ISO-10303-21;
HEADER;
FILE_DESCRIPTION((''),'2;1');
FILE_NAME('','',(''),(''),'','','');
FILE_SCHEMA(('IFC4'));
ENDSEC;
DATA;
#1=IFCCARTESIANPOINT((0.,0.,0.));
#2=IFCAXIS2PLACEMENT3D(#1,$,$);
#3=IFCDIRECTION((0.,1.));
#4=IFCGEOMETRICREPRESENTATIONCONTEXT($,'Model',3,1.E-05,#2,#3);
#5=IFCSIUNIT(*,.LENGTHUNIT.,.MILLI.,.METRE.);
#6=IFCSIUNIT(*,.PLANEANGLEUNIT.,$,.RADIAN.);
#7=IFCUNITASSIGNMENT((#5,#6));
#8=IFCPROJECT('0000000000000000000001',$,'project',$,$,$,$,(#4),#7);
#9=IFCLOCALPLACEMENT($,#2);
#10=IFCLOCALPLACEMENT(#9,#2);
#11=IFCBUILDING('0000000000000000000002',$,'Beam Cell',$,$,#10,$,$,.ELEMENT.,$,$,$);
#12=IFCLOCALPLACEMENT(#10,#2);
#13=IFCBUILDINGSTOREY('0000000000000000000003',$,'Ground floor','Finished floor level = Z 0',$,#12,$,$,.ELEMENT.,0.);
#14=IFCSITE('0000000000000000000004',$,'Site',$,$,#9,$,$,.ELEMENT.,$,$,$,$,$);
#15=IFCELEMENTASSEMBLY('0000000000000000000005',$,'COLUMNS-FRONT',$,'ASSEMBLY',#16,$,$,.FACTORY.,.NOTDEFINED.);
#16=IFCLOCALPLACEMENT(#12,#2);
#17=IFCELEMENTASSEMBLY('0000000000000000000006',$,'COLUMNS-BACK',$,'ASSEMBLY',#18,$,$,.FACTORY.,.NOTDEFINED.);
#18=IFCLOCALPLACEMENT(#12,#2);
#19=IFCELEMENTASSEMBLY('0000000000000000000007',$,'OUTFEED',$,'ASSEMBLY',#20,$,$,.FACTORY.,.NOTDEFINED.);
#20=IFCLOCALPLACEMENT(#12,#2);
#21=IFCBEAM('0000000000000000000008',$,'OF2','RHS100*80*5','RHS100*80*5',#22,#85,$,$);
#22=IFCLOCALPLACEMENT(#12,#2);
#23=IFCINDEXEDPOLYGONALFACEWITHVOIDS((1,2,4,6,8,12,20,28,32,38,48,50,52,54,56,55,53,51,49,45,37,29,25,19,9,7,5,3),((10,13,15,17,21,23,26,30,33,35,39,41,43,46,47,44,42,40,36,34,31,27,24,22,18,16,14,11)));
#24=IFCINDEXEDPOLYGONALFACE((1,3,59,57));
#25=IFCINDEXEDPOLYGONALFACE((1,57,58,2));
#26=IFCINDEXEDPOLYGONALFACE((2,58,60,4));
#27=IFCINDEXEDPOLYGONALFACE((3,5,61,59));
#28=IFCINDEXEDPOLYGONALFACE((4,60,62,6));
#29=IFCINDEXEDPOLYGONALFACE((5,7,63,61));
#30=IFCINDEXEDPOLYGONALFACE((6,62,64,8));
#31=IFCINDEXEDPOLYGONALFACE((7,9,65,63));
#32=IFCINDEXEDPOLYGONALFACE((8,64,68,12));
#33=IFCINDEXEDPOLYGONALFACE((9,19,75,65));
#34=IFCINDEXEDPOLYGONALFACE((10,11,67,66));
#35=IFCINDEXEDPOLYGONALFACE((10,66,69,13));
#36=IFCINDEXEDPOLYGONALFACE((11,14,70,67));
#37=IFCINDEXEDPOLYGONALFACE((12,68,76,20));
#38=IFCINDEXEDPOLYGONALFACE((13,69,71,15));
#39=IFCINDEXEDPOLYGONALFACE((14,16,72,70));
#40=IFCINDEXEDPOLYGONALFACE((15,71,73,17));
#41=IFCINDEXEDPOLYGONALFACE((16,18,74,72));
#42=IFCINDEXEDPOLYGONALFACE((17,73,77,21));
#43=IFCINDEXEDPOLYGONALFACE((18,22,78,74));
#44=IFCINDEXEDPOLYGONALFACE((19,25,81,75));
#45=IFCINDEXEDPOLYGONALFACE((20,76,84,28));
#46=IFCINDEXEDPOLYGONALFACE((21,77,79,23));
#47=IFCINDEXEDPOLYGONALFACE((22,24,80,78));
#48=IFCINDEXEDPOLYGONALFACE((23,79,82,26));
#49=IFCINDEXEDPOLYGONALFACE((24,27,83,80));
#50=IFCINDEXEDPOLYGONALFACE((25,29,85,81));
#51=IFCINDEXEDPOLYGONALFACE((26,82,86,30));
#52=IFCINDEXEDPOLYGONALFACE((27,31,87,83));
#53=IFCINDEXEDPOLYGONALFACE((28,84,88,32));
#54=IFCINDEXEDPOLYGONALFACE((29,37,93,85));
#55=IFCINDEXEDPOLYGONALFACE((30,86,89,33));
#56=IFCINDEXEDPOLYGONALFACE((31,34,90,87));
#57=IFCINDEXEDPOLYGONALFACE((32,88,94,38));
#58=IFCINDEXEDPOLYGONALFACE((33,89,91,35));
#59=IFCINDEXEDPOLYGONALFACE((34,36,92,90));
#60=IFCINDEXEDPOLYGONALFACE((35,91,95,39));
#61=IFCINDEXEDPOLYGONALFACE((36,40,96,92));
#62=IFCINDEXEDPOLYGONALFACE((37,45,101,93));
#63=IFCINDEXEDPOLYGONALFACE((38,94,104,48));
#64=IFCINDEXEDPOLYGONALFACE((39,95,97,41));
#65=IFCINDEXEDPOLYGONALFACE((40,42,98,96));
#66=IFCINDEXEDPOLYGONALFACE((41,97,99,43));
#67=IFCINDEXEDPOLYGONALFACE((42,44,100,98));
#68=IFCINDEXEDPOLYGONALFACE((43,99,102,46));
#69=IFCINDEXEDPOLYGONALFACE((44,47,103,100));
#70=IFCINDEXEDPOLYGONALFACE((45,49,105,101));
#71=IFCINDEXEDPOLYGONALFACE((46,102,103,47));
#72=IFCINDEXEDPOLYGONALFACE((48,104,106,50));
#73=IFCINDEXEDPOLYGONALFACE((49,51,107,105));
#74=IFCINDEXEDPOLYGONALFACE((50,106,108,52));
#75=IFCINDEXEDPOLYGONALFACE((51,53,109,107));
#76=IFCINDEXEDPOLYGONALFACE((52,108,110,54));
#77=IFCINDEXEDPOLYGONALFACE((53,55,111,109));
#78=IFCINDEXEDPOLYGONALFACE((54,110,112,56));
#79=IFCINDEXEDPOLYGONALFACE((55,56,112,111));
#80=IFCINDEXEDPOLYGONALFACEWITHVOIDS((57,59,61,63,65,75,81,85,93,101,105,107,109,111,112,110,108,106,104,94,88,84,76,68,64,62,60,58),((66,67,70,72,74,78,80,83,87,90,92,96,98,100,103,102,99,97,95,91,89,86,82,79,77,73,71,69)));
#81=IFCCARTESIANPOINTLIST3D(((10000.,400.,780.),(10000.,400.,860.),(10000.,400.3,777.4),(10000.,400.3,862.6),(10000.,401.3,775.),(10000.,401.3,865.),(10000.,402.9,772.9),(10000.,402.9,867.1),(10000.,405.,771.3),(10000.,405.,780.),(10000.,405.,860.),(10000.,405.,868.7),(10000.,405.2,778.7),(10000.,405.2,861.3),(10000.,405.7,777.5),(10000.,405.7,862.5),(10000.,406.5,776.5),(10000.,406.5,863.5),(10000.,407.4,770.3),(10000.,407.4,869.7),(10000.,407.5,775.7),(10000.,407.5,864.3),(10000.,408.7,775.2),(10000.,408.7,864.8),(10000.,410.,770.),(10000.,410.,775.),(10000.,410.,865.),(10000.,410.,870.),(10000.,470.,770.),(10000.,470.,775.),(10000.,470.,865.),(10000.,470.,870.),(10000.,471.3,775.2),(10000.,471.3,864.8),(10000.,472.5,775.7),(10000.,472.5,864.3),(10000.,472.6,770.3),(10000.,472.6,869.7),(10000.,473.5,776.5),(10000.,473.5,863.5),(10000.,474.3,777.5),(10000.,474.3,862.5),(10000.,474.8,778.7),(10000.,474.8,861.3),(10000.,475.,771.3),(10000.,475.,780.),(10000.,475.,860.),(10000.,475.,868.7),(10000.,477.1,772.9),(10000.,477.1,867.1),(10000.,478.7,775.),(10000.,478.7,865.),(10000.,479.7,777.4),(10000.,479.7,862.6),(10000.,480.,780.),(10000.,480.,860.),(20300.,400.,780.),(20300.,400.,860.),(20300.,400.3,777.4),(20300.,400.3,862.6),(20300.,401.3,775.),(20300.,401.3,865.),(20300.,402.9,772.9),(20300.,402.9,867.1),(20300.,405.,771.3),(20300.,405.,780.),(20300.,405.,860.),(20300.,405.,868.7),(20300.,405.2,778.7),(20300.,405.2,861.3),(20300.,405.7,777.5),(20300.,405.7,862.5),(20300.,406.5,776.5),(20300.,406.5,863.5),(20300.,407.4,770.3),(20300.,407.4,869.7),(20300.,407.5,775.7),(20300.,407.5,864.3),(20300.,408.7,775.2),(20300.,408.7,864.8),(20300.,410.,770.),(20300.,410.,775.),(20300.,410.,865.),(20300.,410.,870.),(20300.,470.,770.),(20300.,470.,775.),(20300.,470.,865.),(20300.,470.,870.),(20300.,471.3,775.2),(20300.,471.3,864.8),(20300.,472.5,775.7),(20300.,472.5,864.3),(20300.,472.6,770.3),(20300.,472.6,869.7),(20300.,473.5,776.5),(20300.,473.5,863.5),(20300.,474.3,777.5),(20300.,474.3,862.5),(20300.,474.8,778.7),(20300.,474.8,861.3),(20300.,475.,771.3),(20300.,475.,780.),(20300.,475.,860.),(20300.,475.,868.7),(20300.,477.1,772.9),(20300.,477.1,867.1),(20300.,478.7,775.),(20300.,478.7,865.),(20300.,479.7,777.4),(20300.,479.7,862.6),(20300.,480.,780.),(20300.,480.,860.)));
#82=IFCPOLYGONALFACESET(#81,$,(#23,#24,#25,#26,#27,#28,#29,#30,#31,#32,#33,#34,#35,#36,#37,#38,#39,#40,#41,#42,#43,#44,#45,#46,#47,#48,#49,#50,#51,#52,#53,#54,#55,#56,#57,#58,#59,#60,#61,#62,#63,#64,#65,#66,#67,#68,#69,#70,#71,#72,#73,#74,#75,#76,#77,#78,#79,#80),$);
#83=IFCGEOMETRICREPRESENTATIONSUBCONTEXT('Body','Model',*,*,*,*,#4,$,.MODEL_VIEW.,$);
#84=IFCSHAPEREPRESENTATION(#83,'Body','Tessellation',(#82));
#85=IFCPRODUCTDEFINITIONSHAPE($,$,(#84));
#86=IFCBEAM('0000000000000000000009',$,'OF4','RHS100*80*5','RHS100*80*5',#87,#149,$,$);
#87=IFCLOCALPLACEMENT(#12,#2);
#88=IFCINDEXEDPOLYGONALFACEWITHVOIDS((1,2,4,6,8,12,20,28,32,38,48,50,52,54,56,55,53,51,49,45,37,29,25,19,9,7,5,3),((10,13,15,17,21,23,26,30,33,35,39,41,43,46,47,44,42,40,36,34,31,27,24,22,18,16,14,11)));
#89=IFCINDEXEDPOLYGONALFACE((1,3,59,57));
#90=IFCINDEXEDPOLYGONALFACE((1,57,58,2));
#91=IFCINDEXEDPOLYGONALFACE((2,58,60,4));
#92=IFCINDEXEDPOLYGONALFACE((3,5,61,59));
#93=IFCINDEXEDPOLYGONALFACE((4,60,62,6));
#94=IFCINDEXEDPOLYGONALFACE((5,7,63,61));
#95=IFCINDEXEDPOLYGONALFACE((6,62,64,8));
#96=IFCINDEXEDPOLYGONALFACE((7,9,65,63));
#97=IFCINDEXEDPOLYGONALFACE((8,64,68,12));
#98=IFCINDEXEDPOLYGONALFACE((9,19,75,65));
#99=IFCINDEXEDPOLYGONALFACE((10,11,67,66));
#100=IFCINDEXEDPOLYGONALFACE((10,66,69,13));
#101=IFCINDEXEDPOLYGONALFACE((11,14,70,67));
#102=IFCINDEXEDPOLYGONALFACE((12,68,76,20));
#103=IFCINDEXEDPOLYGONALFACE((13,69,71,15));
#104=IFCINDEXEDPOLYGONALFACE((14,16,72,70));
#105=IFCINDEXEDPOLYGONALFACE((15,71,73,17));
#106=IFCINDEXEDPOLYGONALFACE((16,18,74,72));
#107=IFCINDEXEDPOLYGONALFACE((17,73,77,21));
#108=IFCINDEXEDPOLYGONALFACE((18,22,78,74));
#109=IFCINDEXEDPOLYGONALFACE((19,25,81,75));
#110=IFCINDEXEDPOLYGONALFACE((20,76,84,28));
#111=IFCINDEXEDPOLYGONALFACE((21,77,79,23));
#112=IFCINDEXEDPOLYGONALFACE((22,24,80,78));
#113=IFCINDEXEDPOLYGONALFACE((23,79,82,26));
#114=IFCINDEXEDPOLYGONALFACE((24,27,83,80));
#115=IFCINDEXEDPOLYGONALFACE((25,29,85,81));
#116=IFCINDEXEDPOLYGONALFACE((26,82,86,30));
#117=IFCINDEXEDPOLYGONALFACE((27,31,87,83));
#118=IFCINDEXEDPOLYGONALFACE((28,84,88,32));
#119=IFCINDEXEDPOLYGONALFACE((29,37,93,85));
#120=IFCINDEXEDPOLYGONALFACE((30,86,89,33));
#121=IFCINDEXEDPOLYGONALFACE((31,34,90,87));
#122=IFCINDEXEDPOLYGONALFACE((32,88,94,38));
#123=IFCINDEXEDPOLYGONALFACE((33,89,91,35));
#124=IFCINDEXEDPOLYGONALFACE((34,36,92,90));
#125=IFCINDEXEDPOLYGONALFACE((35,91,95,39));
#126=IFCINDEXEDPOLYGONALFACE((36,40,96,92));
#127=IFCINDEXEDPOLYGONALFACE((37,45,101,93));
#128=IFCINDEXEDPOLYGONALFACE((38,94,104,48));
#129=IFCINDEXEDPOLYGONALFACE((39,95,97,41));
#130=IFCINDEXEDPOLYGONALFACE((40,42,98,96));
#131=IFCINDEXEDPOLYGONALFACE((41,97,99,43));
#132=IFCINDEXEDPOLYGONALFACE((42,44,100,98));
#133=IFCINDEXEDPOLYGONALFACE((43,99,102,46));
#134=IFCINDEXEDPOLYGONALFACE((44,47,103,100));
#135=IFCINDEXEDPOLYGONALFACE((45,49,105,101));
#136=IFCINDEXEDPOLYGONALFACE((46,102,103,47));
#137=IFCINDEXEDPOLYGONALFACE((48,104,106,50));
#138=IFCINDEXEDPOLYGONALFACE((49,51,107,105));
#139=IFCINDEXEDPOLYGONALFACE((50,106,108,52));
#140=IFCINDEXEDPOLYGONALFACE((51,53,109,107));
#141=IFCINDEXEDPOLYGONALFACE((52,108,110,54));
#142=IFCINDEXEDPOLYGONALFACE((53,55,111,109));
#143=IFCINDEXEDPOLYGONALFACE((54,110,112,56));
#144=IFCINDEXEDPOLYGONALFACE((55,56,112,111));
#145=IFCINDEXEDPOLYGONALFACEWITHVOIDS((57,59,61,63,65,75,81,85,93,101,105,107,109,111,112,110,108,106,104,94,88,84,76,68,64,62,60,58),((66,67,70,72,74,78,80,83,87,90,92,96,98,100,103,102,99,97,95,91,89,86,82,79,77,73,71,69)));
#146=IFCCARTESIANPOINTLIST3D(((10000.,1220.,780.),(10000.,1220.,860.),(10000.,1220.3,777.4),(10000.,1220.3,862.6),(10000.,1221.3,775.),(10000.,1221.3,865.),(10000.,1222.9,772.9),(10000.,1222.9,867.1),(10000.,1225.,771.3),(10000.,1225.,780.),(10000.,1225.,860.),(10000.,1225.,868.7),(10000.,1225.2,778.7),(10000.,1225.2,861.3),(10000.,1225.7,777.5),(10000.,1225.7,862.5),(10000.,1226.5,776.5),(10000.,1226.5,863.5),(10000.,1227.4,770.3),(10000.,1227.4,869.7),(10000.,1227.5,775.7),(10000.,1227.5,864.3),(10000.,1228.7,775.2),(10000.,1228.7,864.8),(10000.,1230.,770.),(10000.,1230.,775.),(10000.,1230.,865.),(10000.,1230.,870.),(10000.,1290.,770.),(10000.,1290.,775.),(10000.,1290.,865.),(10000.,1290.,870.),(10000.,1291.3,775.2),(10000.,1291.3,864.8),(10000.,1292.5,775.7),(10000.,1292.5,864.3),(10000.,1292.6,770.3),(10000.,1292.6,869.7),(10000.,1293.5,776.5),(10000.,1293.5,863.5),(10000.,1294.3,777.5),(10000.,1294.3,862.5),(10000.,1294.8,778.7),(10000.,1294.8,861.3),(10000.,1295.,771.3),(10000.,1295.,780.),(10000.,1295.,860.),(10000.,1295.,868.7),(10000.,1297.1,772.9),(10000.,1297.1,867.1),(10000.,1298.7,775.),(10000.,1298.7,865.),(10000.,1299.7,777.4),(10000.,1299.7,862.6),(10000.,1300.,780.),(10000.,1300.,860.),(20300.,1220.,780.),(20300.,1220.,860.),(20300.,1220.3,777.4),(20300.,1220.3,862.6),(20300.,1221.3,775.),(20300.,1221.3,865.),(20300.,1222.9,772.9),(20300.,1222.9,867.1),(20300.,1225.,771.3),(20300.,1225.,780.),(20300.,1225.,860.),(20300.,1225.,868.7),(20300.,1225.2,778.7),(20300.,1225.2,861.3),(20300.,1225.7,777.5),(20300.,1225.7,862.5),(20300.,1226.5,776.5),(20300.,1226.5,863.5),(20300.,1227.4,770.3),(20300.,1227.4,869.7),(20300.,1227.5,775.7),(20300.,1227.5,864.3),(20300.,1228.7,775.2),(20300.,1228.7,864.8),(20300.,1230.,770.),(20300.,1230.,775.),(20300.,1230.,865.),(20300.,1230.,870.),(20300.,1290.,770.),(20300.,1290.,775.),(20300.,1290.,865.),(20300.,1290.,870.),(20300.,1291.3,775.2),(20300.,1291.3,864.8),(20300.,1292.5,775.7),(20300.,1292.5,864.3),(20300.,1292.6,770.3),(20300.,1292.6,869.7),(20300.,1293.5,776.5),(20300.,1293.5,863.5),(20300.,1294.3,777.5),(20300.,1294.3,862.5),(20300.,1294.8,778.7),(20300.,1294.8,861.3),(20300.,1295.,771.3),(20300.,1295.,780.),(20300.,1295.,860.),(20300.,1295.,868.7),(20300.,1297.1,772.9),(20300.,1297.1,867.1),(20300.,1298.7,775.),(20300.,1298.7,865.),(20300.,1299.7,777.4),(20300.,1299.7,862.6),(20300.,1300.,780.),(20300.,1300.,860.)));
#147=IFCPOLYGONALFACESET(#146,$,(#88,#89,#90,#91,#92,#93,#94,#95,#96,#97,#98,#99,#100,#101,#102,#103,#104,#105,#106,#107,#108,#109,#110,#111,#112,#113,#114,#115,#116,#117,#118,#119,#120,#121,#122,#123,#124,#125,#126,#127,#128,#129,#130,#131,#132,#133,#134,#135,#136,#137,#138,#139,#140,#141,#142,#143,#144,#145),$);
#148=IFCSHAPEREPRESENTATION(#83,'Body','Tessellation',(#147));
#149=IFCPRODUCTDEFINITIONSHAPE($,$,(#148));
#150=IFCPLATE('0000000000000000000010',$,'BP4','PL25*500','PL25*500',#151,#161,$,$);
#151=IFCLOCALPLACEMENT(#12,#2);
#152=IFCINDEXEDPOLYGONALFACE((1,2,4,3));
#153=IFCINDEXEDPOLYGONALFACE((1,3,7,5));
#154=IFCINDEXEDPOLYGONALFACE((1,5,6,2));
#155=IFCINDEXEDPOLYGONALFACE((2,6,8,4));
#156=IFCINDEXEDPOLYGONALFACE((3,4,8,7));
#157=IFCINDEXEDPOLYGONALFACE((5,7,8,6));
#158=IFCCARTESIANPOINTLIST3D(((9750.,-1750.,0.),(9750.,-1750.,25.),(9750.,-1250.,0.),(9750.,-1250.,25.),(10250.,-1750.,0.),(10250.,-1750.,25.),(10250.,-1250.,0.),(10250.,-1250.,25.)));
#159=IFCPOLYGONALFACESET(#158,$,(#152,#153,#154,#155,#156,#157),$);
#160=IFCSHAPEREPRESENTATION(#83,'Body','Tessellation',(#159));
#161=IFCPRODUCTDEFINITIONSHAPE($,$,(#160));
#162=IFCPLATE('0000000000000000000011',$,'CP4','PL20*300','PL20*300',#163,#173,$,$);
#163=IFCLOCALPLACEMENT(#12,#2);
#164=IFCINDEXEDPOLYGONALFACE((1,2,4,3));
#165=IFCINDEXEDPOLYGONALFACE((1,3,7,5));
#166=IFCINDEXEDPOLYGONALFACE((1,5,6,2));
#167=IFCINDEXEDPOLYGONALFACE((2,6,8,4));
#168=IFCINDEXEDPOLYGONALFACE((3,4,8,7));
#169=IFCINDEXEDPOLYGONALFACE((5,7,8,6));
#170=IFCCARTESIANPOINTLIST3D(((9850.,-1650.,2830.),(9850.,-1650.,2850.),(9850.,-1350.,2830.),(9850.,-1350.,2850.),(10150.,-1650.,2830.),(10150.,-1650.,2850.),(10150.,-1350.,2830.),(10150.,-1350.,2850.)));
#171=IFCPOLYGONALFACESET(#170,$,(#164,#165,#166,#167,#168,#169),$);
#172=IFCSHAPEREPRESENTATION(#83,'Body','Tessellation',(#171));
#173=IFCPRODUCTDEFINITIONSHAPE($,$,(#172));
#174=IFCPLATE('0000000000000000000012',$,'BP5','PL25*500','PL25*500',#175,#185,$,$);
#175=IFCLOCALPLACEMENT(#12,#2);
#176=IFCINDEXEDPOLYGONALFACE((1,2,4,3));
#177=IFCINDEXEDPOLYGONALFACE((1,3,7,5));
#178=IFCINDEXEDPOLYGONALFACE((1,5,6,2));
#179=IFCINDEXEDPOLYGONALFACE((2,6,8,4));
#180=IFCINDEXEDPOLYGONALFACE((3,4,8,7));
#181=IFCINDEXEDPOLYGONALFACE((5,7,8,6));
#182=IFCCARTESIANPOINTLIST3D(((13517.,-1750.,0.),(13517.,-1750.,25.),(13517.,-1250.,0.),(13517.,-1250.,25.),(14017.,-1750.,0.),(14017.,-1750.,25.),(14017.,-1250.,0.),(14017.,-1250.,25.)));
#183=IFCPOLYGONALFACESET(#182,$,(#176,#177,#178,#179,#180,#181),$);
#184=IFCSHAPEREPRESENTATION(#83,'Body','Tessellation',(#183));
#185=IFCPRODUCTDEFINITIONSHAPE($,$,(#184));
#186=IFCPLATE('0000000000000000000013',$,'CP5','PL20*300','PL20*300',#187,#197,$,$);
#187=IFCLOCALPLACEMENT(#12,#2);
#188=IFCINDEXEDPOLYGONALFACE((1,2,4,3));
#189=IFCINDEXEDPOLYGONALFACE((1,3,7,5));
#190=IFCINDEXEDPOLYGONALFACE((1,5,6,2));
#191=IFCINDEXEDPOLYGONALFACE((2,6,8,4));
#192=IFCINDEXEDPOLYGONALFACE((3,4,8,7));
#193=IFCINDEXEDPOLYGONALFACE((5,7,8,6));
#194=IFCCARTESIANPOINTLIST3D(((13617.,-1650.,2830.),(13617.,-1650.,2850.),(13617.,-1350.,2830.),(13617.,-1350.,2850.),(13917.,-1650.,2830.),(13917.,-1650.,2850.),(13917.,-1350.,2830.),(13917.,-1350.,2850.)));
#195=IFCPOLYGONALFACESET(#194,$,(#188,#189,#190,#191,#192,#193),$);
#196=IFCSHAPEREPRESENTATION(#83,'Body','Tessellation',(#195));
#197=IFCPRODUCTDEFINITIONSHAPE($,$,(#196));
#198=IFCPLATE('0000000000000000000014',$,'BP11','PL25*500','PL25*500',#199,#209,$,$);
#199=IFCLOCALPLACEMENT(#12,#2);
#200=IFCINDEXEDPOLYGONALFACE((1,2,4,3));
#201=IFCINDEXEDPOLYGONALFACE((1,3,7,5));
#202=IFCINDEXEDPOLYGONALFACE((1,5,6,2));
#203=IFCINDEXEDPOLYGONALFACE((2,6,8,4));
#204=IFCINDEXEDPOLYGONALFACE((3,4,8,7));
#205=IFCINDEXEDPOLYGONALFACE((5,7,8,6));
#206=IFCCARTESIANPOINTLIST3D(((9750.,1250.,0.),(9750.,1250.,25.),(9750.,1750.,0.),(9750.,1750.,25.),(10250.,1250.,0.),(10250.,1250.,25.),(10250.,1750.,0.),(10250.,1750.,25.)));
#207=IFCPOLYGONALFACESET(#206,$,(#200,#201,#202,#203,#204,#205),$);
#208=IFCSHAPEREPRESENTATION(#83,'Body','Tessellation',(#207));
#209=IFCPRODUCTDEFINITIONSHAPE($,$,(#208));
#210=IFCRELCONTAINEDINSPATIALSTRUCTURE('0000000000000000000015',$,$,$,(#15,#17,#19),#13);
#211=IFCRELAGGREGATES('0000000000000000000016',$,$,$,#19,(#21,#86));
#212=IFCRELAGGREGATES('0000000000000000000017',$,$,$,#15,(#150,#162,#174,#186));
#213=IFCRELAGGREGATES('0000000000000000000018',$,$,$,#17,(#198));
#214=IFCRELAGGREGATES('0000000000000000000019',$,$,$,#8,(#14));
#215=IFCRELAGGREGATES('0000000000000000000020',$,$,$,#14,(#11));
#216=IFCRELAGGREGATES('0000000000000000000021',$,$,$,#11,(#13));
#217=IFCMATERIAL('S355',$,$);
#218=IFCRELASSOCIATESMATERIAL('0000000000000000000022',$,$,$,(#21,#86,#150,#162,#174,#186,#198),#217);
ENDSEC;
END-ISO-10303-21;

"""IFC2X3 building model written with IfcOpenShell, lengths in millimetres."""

from ifc_helpers import new_model, si_unit, direction, frame, origin, origin_2d, place, context, subcontext, project, spatial, rectangle, hollow_rectangle, extrude, material, element, aggregate, save


model = new_model("IFC2X3")

# Units and contexts
model_context = context("Model", 3, precision=1e-05, world=origin(), true_north=direction((0.0, 1.0)))
body_context = subcontext(model_context, "Body", "Model", "MODEL_VIEW")
ifc_project = project(units=[si_unit("LENGTHUNIT", "METRE", prefix="MILLI"), si_unit("PLANEANGLEUNIT", "RADIAN")], contexts=[model_context])

# Site, building, storey
site_placement = place(None, origin())
site = spatial("IfcSite", under=ifc_project, at=site_placement, Name="Site", CompositionType="ELEMENT")
building_placement = place(site_placement, origin())
building = spatial("IfcBuilding", under=site, at=building_placement, Name="Beam Cell", CompositionType="ELEMENT")
storey_placement = place(building_placement, origin())
storey = spatial("IfcBuildingStorey", under=building, at=storey_placement, Name="Ground floor", Description="Finished floor level = Z 0", CompositionType="ELEMENT", Elevation=0.0)

# Element assemblies
assembly_1_placement = place(storey_placement, origin())
assembly_1 = element("IfcElementAssembly", 1, at=assembly_1_placement, inside=storey, Name="COLUMNS-FRONT", ObjectType="ASSEMBLY", AssemblyPlace="FACTORY", PredefinedType="NOTDEFINED")
ifc_material = material(Name="S355")
assembly_2_placement = place(storey_placement, origin())
assembly_2 = element("IfcElementAssembly", 2, at=assembly_2_placement, inside=storey, Name="COLUMNS-BACK", ObjectType="ASSEMBLY", AssemblyPlace="FACTORY", PredefinedType="NOTDEFINED")
assembly_3_placement = place(storey_placement, origin())
assembly_3 = element("IfcElementAssembly", 3, at=assembly_3_placement, inside=storey, Name="OUTFEED", ObjectType="ASSEMBLY", AssemblyPlace="FACTORY", PredefinedType="NOTDEFINED")

# Beams
beam_1_placement = place(storey_placement, frame((10000.0, 440.0, 820.0), z_axis=(1.0, 0.0, 0.0), x_axis=(0.0, 1.0, 0.0)))
beam_1 = element("IfcBeam", 4, at=beam_1_placement, material=ifc_material, Name="OF2", Description="RHS100*80*5", ObjectType="RHS100*80*5", context=body_context, shape_type="SweptSolid", body=[
    extrude(hollow_rectangle(XDim=80.0, YDim=100.0, WallThickness=5.0, InnerFilletRadius=5.0, OuterFilletRadius=10.0, at=origin_2d()), origin(), (0.0, 0.0, 1.0), 10300.0),
])
beam_2_placement = place(storey_placement, frame((10000.0, 1260.0, 820.0), z_axis=(1.0, 0.0, 0.0), x_axis=(0.0, 1.0, 0.0)))
beam_2 = element("IfcBeam", 5, at=beam_2_placement, material=ifc_material, Name="OF4", Description="RHS100*80*5", ObjectType="RHS100*80*5", context=body_context, shape_type="SweptSolid", body=[
    extrude(hollow_rectangle(XDim=80.0, YDim=100.0, WallThickness=5.0, InnerFilletRadius=5.0, OuterFilletRadius=10.0, at=origin_2d()), origin(), (0.0, 0.0, 1.0), 10300.0),
])
aggregate(assembly_3, [beam_1, beam_2])

# Plates
plate_1_placement = place(storey_placement, frame((10000.0, -1500.0, 0.0), z_axis=(0.0, 0.0, 1.0), x_axis=(1.0, 0.0, 0.0)))
plate_1 = element("IfcPlate", 6, at=plate_1_placement, material=ifc_material, Name="BP4", Description="PL25*500", ObjectType="PL25*500", context=body_context, shape_type="SweptSolid", body=[
    extrude(rectangle(XDim=500.0, YDim=500.0, at=origin_2d()), origin(), (0.0, 0.0, 1.0), 25.0),
])
plate_2_placement = place(storey_placement, frame((10000.0, -1500.0, 2830.0), z_axis=(0.0, 0.0, 1.0), x_axis=(1.0, 0.0, 0.0)))
plate_2 = element("IfcPlate", 7, at=plate_2_placement, material=ifc_material, Name="CP4", Description="PL20*300", ObjectType="PL20*300", context=body_context, shape_type="SweptSolid", body=[
    extrude(rectangle(XDim=300.0, YDim=300.0, at=origin_2d()), origin(), (0.0, 0.0, 1.0), 20.0),
])
plate_3_placement = place(storey_placement, frame((13767.0, -1500.0, 0.0), z_axis=(0.0, 0.0, 1.0), x_axis=(1.0, 0.0, 0.0)))
plate_3 = element("IfcPlate", 8, at=plate_3_placement, material=ifc_material, Name="BP5", Description="PL25*500", ObjectType="PL25*500", context=body_context, shape_type="SweptSolid", body=[
    extrude(rectangle(XDim=500.0, YDim=500.0, at=origin_2d()), origin(), (0.0, 0.0, 1.0), 25.0),
])
plate_4_placement = place(storey_placement, frame((13767.0, -1500.0, 2830.0), z_axis=(0.0, 0.0, 1.0), x_axis=(1.0, 0.0, 0.0)))
plate_4 = element("IfcPlate", 9, at=plate_4_placement, material=ifc_material, Name="CP5", Description="PL20*300", ObjectType="PL20*300", context=body_context, shape_type="SweptSolid", body=[
    extrude(rectangle(XDim=300.0, YDim=300.0, at=origin_2d()), origin(), (0.0, 0.0, 1.0), 20.0),
])
aggregate(assembly_1, [plate_1, plate_2, plate_3, plate_4])
plate_5_placement = place(storey_placement, frame((10000.0, 1500.0, 0.0), z_axis=(0.0, 0.0, 1.0), x_axis=(1.0, 0.0, 0.0)))
plate_5 = element("IfcPlate", 10, at=plate_5_placement, material=ifc_material, Name="BP11", Description="PL25*500", ObjectType="PL25*500", context=body_context, shape_type="SweptSolid", body=[
    extrude(rectangle(XDim=500.0, YDim=500.0, at=origin_2d()), origin(), (0.0, 0.0, 1.0), 25.0),
])
aggregate(assembly_2, [plate_5])

save(model, "model.ifc")
